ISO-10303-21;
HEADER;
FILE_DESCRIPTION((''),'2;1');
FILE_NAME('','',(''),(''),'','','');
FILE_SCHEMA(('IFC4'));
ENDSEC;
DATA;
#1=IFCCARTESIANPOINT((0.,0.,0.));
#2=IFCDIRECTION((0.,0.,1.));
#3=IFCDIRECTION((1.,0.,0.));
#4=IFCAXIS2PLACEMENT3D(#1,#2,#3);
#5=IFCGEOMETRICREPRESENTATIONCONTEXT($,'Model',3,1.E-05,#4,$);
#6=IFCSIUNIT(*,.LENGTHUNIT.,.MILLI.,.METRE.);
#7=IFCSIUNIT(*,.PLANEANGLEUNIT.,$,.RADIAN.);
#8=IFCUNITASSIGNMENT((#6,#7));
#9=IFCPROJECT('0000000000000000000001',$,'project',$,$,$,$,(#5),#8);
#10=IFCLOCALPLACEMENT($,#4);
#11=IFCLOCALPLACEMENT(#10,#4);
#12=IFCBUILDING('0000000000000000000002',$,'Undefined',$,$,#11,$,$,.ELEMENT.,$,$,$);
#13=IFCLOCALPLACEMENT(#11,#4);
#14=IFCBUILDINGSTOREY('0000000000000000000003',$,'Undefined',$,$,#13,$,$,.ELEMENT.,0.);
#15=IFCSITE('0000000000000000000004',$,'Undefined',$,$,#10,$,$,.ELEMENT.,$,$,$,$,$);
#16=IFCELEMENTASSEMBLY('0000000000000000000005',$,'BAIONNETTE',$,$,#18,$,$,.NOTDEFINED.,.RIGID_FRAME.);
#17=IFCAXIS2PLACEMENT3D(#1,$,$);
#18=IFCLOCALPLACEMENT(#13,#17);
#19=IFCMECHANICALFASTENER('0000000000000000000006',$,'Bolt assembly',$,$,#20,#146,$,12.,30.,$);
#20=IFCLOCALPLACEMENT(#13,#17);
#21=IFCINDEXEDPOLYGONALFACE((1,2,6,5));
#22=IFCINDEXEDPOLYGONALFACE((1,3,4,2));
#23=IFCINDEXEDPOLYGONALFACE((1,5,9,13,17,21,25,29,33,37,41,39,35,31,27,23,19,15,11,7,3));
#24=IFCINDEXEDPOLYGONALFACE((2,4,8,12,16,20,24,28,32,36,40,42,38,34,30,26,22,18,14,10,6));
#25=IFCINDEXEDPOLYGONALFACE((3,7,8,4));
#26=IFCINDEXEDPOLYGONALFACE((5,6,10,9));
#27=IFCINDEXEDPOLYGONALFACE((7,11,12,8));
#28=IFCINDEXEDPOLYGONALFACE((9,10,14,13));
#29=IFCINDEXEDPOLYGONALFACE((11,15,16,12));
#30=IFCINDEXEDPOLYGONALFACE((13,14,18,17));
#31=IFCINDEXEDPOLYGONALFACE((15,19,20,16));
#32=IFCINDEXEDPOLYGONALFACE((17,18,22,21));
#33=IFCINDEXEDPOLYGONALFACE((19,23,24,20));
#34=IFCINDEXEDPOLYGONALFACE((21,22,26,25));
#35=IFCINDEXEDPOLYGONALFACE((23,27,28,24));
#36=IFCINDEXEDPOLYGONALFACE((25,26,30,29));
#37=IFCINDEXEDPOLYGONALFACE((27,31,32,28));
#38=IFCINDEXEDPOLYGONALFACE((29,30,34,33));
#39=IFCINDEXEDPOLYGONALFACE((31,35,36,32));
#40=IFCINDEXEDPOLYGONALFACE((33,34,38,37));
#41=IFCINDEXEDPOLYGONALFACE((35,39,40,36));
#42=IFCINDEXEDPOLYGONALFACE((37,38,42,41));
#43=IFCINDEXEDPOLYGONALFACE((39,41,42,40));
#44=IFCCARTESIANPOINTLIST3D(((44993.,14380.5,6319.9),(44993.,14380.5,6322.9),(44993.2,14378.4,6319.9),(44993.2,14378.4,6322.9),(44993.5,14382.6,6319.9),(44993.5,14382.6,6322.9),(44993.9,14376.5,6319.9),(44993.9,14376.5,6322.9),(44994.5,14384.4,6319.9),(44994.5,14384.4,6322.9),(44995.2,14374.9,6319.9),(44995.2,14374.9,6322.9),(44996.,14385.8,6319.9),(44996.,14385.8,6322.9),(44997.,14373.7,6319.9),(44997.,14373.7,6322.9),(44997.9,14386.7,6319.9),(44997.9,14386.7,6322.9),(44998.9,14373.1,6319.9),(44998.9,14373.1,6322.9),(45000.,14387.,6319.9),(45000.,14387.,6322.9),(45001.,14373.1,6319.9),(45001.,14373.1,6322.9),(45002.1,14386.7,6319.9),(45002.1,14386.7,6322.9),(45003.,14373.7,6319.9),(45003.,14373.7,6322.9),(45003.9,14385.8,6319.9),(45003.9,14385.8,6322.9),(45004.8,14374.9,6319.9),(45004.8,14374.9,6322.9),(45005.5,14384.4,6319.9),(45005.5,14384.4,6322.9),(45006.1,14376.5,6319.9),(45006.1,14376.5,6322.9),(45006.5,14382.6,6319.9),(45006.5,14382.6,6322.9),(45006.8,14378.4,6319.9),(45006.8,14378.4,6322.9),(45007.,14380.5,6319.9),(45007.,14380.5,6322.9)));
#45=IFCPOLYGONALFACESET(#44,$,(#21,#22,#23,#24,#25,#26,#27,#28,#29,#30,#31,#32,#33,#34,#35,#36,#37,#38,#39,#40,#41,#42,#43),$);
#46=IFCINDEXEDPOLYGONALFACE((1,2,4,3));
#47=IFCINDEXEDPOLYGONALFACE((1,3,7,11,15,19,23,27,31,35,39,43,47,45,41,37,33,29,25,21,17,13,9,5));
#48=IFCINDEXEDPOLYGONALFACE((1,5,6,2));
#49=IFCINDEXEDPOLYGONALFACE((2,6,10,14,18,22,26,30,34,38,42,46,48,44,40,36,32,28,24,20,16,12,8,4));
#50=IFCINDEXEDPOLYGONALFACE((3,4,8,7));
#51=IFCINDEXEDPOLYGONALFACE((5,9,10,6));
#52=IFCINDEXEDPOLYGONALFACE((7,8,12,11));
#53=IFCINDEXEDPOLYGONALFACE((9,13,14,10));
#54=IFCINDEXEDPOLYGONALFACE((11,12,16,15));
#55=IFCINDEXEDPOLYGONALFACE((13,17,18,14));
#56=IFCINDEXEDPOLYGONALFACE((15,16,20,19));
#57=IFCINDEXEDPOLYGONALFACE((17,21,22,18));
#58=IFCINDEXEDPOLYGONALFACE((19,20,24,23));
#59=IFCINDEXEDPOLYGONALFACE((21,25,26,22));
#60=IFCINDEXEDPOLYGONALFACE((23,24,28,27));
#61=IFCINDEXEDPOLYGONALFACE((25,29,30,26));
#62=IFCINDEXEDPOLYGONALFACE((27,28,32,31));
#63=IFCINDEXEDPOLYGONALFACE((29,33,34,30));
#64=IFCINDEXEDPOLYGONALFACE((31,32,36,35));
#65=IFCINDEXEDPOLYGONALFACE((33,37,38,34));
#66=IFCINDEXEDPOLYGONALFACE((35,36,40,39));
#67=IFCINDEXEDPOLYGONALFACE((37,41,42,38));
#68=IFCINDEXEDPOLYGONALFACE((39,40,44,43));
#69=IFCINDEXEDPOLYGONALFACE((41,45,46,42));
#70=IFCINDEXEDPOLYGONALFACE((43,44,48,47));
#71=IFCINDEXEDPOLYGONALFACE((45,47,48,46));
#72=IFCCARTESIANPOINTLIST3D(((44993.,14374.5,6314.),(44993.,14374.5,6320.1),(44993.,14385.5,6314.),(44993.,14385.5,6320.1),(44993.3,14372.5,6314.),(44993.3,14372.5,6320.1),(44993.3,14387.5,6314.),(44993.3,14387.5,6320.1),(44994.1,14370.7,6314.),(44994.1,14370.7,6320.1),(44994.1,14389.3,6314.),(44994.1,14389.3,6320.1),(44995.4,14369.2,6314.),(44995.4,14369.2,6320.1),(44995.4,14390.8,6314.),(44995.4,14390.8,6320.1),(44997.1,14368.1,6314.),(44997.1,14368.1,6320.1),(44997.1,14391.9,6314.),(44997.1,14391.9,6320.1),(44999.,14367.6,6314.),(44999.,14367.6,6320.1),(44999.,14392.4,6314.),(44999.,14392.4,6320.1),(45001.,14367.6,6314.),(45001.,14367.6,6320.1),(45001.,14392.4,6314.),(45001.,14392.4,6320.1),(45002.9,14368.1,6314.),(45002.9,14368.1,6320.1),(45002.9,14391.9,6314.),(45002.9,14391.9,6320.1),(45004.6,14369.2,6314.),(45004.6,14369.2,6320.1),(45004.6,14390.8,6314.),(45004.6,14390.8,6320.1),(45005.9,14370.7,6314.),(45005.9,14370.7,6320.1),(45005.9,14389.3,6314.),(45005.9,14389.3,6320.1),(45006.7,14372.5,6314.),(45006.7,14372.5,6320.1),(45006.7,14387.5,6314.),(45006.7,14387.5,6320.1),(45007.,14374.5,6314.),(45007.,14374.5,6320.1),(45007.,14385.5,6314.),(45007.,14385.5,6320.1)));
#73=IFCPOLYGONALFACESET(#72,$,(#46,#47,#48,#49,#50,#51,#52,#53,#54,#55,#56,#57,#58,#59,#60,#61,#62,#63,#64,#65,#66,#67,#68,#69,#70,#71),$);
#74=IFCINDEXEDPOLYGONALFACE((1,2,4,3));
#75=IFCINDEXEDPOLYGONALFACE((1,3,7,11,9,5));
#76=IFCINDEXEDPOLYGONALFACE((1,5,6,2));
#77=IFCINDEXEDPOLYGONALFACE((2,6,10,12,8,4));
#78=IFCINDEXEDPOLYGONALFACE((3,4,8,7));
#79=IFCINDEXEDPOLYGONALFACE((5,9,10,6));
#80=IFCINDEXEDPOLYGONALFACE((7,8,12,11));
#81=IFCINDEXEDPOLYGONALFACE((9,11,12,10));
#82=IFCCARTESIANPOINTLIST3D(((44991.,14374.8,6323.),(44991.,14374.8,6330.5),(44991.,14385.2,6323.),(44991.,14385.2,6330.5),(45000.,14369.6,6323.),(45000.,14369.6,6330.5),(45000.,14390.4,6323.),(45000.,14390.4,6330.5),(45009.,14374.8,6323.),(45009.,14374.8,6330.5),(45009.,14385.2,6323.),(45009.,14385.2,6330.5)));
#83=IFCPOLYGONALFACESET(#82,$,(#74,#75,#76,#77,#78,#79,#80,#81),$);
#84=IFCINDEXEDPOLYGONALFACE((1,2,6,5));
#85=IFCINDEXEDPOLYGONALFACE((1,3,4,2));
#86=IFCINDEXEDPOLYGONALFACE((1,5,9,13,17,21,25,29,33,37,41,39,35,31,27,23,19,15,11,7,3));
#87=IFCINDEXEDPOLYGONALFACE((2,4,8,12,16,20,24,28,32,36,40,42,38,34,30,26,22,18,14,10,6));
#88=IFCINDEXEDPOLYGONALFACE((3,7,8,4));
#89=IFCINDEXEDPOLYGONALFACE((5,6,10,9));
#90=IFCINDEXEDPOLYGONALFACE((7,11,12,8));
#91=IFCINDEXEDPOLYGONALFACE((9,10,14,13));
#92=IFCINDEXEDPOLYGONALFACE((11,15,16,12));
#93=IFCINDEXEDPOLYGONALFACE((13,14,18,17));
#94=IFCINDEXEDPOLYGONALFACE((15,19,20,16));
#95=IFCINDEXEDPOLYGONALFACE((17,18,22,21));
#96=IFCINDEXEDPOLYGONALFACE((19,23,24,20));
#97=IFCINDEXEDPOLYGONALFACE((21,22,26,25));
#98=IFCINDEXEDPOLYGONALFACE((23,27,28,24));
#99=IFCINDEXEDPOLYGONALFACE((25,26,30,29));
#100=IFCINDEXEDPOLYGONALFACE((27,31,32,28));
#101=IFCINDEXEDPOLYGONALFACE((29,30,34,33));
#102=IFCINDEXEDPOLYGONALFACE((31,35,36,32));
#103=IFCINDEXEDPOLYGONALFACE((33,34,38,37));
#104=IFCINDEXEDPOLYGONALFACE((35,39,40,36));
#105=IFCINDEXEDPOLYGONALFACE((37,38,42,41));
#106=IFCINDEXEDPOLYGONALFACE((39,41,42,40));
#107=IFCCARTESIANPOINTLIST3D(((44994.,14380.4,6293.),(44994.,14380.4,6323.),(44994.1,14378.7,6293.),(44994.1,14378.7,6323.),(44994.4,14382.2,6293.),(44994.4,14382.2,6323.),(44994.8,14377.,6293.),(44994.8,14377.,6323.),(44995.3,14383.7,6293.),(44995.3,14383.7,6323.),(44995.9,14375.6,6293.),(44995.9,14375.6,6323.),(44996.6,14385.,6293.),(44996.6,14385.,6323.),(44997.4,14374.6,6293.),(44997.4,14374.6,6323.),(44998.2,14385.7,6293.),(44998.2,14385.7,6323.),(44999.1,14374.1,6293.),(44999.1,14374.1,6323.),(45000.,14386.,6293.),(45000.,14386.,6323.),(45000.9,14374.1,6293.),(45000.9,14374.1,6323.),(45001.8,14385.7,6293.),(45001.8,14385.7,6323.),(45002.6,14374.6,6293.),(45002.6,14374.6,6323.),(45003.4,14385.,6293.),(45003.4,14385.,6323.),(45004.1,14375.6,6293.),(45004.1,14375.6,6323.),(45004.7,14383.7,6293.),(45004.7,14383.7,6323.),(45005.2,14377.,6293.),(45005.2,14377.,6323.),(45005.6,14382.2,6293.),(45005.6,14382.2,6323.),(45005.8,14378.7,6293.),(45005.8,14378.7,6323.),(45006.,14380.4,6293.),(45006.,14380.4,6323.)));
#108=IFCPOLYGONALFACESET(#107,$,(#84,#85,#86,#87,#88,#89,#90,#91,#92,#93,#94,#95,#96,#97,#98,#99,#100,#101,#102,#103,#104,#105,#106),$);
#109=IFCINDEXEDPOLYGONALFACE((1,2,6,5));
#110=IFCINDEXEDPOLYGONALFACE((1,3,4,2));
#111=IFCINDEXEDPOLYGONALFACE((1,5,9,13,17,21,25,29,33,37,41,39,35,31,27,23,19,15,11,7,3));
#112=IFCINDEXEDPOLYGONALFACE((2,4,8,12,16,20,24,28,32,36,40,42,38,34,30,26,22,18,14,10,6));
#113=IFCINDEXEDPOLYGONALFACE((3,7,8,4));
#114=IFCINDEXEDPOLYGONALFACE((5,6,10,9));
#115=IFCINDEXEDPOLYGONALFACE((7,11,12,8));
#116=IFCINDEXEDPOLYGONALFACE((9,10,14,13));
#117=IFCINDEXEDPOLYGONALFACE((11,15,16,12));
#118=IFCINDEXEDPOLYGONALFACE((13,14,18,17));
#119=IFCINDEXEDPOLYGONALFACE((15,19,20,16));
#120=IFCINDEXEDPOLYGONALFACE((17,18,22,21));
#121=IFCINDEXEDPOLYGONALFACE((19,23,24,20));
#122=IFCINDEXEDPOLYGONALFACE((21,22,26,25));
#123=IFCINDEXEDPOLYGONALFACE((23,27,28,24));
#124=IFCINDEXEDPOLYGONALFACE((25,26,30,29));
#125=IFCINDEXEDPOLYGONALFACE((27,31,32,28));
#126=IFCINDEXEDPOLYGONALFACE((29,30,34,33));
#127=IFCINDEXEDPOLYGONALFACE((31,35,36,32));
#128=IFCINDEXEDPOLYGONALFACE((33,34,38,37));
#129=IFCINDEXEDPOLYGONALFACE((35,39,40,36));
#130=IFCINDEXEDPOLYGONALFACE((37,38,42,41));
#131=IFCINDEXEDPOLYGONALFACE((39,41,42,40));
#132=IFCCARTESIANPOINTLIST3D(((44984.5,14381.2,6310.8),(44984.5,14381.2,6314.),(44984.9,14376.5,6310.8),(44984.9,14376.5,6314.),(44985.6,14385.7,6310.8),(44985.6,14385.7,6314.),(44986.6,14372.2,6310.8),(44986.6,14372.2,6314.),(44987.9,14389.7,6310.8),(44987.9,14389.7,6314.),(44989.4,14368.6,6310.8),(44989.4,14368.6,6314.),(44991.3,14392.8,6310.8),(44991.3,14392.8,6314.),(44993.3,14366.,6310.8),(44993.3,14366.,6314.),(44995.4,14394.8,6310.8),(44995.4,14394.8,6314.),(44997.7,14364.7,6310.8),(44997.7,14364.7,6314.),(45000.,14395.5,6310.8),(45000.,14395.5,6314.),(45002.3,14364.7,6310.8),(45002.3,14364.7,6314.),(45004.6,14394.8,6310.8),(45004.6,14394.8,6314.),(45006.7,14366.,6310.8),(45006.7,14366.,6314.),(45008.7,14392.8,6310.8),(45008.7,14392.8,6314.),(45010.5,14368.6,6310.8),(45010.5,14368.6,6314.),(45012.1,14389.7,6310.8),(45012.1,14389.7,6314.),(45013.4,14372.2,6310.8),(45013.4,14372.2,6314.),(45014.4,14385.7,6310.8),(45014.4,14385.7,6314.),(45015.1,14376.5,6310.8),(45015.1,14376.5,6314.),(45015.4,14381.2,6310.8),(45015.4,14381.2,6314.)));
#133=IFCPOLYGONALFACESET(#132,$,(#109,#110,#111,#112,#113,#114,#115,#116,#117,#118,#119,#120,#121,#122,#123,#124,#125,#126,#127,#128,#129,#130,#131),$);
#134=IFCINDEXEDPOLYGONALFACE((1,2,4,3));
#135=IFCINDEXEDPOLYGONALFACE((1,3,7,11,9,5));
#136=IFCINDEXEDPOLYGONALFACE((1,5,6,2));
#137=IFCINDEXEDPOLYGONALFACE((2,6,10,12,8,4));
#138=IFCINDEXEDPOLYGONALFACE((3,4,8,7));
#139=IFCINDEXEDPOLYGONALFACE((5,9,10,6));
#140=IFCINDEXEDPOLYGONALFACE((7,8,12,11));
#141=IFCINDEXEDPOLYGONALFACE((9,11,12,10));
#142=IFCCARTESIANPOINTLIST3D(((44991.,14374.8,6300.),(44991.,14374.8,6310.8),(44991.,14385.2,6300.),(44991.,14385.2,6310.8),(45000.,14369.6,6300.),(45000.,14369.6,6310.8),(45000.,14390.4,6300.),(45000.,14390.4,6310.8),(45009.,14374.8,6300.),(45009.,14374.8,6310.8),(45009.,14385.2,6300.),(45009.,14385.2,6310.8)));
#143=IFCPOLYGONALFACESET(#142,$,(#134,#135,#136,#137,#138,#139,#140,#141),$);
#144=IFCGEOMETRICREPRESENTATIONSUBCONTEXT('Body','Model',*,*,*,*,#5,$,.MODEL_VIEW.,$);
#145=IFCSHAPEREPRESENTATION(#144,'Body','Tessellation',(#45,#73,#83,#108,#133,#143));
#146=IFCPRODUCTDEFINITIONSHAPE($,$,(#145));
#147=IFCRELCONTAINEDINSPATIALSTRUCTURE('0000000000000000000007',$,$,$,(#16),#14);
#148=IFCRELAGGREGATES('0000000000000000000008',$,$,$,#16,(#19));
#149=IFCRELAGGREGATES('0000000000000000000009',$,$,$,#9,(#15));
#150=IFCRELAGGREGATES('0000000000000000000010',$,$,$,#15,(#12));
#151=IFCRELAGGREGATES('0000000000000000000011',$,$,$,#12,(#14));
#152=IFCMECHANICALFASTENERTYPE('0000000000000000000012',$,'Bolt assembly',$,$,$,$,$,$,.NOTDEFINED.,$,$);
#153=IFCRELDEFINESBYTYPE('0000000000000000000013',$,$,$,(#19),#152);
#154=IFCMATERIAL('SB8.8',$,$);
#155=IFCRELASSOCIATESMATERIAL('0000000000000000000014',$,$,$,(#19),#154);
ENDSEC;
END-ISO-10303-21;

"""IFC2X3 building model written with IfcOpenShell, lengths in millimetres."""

from ifc_helpers import new_model, si_unit, frame, frame_2d, origin_with_axes, origin_2d_with_axis, place, context, subcontext, project, spatial, polyline, circle_curve, parameter, trimmed, segment, composite_curve, circle, outline, extrude, source, transform, mapped, material, type_object, element, aggregate, save


model = new_model("IFC2X3")

# Units and contexts
model_context = context("Model", 3, precision=1e-05, world=origin_with_axes())
body_context = subcontext(model_context, "Body", "Model", "MODEL_VIEW")
ifc_project = project(units=[si_unit("LENGTHUNIT", "METRE", prefix="MILLI"), si_unit("PLANEANGLEUNIT", "RADIAN")], contexts=[model_context])

# Site, building, storey
site_placement = place(None, origin_with_axes())
site = spatial("IfcSite", under=ifc_project, at=site_placement, Name="Undefined", CompositionType="ELEMENT")
building_placement = place(site_placement, origin_with_axes())
building = spatial("IfcBuilding", under=site, at=building_placement, Name="Undefined", CompositionType="ELEMENT")
storey_placement = place(building_placement, origin_with_axes())
storey = spatial("IfcBuildingStorey", under=building, at=storey_placement, Name="Undefined", CompositionType="ELEMENT", Elevation=0.0)

# Element assembly
assembly_1_placement = place(storey_placement, origin_with_axes())
assembly_1 = element("IfcElementAssembly", 1, at=assembly_1_placement, inside=storey, Name="BAIONNETTE", AssemblyPlace="NOTDEFINED", PredefinedType="RIGID_FRAME")

# Shared definitions
ifc_material_1 = material(Name="SB8.8")
mechanical_fastener_type = type_object("IfcMechanicalFastenerType", Name="Bolt assembly")

# Mechanical fastener
shared_shape_1 = source(origin_with_axes(), body_context, "Body", "SweptSolid", [
    extrude(circle(Radius=7.0, at=origin_2d_with_axis()), frame((0.0, -2.9, 0.0), z_axis=(0.0, 1.0, 0.0), x_axis=(1.0, 0.0, 0.0)), (0.0, 0.0, 1.0), 3.0),
    extrude(outline(composite_curve([segment(polyline([(-5.5, 7.0), (5.5, 7.0)]), True, "CONTINUOUS"), segment(trimmed(circle_curve(frame_2d((5.5, 0.0), x_axis=(0.0, 1.0)), 7.0), [parameter(0.0)], [parameter(3.141593)], False, "PARAMETER"), True, "CONTINUOUS"), segment(polyline([(5.5, -7.0), (-5.5, -7.0)]), True, "CONTINUOUS"), segment(trimmed(circle_curve(frame_2d((-5.5, 0.0), x_axis=(0.0, -1.0)), 7.0), [parameter(0.0)], [parameter(3.141593)], False, "PARAMETER"), True, "DISCONTINUOUS")], self_intersect=False)), frame((0.0, -0.1, 0.0), z_axis=(0.0, 1.0, 0.0), x_axis=(1.0, 0.0, 0.0)), (0.0, 0.0, 1.0), 6.1),
    extrude(outline(polyline([(10.4, 0.0), (5.2, 9.0), (-5.2, 9.0), (-10.4, 0.0), (-5.2, -9.0), (5.2, -9.0), (10.4, 0.0)])), frame((0.0, -10.5, 0.0), z_axis=(0.0, 1.0, 0.0), x_axis=(1.0, 0.0, 0.0)), (0.0, 0.0, 1.0), 7.5),
    extrude(circle(Radius=6.0, at=origin_2d_with_axis()), frame((0.0, -3.0, 0.0), z_axis=(0.0, 1.0, 0.0), x_axis=(1.0, 0.0, 0.0)), (0.0, 0.0, 1.0), 30.0),
    extrude(circle(Radius=15.5, at=origin_2d_with_axis()), frame((0.0, 6.0, 0.0), z_axis=(0.0, 1.0, 0.0), x_axis=(1.0, 0.0, 0.0)), (0.0, 0.0, 1.0), 3.2),
    extrude(outline(polyline([(10.4, 0.0), (5.2, 9.0), (-5.2, 9.0), (-10.4, 0.0), (-5.2, -9.0), (5.2, -9.0), (10.4, 0.0)])), frame((0.0, 9.2, 0.0), z_axis=(0.0, 1.0, 0.0), x_axis=(1.0, 0.0, 0.0)), (0.0, 0.0, 1.0), 10.8),
])
mechanical_fastener_1_placement = place(assembly_1_placement, frame((45000.0, 14380.0, 6320.0), z_axis=(-1.0, 0.0, 0.0), x_axis=(0.0, 1.0, 0.0)))
mechanical_fastener_1 = element("IfcMechanicalFastener", 2, at=mechanical_fastener_1_placement, type_object=mechanical_fastener_type, material=ifc_material_1, Name="Bolt assembly", NominalDiameter=12.0, NominalLength=30.0, context=body_context, shape_type="MappedRepresentation", body=[
    mapped(shared_shape_1, transform((0.0, 0.0, 0.0))),
])

aggregate(assembly_1, [mechanical_fastener_1])

save(model, "model.ifc")
